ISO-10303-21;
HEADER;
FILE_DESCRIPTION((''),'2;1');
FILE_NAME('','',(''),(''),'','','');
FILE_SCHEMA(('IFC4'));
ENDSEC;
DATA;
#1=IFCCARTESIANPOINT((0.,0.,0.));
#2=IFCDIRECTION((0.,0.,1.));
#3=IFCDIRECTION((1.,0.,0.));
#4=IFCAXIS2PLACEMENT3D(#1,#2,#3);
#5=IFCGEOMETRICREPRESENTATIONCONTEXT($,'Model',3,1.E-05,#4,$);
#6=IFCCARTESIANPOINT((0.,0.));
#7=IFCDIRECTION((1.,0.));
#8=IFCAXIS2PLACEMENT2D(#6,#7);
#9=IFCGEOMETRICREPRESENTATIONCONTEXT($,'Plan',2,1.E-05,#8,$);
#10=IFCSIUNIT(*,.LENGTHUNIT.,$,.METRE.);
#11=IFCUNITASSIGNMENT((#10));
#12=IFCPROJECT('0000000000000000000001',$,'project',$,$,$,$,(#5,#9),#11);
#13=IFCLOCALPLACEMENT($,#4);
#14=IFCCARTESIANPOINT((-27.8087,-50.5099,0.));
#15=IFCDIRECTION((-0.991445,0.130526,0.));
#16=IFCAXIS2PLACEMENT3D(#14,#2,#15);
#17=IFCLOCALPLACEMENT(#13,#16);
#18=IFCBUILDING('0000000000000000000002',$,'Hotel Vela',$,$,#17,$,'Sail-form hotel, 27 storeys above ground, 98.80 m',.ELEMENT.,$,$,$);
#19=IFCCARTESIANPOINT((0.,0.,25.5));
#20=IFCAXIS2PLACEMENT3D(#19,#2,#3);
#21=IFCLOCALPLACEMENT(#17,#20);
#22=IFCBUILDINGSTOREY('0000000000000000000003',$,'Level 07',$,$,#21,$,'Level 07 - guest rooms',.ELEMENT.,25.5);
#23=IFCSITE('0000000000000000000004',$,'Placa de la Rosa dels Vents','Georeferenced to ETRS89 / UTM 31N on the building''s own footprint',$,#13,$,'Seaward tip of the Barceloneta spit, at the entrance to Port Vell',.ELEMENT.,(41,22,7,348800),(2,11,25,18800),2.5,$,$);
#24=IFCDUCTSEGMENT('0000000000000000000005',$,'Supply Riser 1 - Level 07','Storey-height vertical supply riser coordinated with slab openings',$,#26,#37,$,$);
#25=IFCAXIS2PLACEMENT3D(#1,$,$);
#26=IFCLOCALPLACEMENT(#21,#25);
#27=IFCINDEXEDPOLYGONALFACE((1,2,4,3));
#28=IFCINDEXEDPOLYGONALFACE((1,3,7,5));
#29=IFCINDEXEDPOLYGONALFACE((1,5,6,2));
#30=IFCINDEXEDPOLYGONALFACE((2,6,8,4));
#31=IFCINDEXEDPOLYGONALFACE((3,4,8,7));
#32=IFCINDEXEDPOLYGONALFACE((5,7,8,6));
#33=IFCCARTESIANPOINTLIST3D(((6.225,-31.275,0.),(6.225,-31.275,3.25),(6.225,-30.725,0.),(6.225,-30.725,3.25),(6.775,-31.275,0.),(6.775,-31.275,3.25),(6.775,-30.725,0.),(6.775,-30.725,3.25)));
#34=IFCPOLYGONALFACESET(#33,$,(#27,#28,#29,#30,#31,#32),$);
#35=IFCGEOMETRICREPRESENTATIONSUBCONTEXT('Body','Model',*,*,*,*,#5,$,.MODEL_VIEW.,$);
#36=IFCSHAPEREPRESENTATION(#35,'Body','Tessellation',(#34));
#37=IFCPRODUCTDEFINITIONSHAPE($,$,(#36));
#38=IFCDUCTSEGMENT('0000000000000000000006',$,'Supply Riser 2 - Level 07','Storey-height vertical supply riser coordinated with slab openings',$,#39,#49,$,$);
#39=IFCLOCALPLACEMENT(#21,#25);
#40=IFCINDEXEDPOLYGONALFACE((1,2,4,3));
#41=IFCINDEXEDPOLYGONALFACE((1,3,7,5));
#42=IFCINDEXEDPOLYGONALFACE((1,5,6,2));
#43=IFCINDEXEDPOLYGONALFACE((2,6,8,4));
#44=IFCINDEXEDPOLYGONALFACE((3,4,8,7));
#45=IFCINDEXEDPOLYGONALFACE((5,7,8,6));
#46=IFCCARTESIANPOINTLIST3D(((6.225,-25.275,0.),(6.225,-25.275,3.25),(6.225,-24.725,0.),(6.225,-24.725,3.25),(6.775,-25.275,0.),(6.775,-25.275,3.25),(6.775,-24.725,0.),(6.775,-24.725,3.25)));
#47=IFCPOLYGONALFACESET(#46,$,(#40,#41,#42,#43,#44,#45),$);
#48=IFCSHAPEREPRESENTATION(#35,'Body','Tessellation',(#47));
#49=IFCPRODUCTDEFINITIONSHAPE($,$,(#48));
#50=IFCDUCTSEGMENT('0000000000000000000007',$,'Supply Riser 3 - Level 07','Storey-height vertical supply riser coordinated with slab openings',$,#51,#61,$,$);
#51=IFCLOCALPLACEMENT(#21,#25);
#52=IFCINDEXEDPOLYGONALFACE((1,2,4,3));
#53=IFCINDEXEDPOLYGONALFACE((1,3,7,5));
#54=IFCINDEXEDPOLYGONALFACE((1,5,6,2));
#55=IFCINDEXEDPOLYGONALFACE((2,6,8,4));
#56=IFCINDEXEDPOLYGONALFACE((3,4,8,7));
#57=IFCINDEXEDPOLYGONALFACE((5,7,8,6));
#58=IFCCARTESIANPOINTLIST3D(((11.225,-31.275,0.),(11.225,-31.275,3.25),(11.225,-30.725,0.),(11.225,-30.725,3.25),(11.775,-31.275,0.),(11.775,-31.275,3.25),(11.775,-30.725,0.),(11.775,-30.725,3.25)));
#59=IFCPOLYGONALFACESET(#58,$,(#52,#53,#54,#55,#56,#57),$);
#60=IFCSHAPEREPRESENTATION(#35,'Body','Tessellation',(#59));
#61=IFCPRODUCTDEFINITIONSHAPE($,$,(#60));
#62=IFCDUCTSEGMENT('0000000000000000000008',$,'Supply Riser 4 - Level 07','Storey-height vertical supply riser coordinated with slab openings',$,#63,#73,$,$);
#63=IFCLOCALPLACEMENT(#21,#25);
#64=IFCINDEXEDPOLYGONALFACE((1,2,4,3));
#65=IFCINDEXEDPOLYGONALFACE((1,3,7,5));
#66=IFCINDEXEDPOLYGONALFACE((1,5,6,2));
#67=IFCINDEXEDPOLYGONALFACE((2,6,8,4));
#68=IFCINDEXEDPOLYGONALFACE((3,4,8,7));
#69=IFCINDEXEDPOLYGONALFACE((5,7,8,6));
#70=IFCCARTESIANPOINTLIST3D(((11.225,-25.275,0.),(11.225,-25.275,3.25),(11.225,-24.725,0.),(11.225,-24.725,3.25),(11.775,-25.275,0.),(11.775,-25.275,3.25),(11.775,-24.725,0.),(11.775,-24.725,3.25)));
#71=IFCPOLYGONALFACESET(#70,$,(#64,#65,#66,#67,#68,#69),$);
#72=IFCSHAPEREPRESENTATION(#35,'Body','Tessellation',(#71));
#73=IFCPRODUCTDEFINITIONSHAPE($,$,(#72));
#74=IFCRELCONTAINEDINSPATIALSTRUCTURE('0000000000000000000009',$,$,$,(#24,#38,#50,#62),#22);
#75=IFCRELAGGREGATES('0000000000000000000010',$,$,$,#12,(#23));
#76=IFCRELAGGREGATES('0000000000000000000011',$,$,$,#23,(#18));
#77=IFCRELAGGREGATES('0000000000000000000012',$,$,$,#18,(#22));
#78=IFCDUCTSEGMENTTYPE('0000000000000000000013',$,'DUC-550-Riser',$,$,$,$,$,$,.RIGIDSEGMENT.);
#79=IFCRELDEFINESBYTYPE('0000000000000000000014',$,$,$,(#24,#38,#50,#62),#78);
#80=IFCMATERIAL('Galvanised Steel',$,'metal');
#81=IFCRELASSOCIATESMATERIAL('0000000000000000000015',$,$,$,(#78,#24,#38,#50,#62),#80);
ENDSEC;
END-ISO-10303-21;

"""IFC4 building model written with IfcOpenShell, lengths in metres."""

from ifc_helpers import new_model, si_unit, frame, origin_with_axes, origin_2d_with_axis, place, context, subcontext, project, spatial, line, indexed_curve, outline, extrude, material, type_object, element, save


model = new_model("IFC4")

# Units and contexts
model_context = context("Model", 3, precision=1e-05, world=origin_with_axes())
plan_context = context("Plan", 2, precision=1e-05, world=origin_2d_with_axis())
body_context = subcontext(model_context, "Body", "Model", "MODEL_VIEW")
ifc_project = project(units=[si_unit("LENGTHUNIT", "METRE")], contexts=[model_context, plan_context])

# Site, building, storey
site_placement = place(None, origin_with_axes())
site = spatial("IfcSite", under=ifc_project, at=site_placement, Name="Placa de la Rosa dels Vents", Description="Georeferenced to ETRS89 / UTM 31N on the building's own footprint", LongName="Seaward tip of the Barceloneta spit, at the entrance to Port Vell", CompositionType="ELEMENT", RefLatitude=(41, 22, 7, 348800), RefLongitude=(2, 11, 25, 18800), RefElevation=2.5)
building_placement = place(site_placement, frame((-27.8087, -50.5099, 0.0), z_axis=(0.0, 0.0, 1.0), x_axis=(-0.991445, 0.130526, 0.0)))
building = spatial("IfcBuilding", under=site, at=building_placement, Name="Hotel Vela", LongName="Sail-form hotel, 27 storeys above ground, 98.80 m", CompositionType="ELEMENT")
storey_placement = place(building_placement, frame((0.0, 0.0, 25.5), z_axis=(0.0, 0.0, 1.0), x_axis=(1.0, 0.0, 0.0)))
storey = spatial("IfcBuildingStorey", under=building, at=storey_placement, Name="Level 07", LongName="Level 07 - guest rooms", CompositionType="ELEMENT", Elevation=25.5)

# Duct segments
ifc_material = material(Name="Galvanised Steel", Category="metal")
duct_segment_type = type_object("IfcDuctSegmentType", Name="DUC-550-Riser", PredefinedType="RIGIDSEGMENT", material=ifc_material)
for number, where, z_axis, x_axis, name in (
    (1, (6.225, -31.275, 0.0), (0.0, 0.0, 1.0), (1.0, 0.0, 0.0), "Supply Riser 1 - Level 07"),
    (2, (6.225, -25.275, 0.0), (0.0, 0.0, 1.0), (1.0, 0.0, 0.0), "Supply Riser 2 - Level 07"),
    (3, (11.225, -31.275, 0.0), (0.0, 0.0, 1.0), (1.0, 0.0, 0.0), "Supply Riser 3 - Level 07"),
    (4, (11.225, -25.275, 0.0), (0.0, 0.0, 1.0), (1.0, 0.0, 0.0), "Supply Riser 4 - Level 07"),
):
    element("IfcDuctSegment", number, at=place(storey_placement, frame(where, z_axis=z_axis, x_axis=x_axis)), inside=storey, type_object=duct_segment_type, material=ifc_material, Name=name, Description="Storey-height vertical supply riser coordinated with slab openings", context=body_context, shape_type="SweptSolid", body=[
        extrude(outline(indexed_curve([(0.0, 0.0), (0.55, 0.0), (0.55, 0.55), (0.0, 0.55)], segments=[line(1, 2, 3, 4, 1)])), origin_with_axes(), (0.0, 0.0, 1.0), 3.25),
    ])

save(model, "model.ifc")
